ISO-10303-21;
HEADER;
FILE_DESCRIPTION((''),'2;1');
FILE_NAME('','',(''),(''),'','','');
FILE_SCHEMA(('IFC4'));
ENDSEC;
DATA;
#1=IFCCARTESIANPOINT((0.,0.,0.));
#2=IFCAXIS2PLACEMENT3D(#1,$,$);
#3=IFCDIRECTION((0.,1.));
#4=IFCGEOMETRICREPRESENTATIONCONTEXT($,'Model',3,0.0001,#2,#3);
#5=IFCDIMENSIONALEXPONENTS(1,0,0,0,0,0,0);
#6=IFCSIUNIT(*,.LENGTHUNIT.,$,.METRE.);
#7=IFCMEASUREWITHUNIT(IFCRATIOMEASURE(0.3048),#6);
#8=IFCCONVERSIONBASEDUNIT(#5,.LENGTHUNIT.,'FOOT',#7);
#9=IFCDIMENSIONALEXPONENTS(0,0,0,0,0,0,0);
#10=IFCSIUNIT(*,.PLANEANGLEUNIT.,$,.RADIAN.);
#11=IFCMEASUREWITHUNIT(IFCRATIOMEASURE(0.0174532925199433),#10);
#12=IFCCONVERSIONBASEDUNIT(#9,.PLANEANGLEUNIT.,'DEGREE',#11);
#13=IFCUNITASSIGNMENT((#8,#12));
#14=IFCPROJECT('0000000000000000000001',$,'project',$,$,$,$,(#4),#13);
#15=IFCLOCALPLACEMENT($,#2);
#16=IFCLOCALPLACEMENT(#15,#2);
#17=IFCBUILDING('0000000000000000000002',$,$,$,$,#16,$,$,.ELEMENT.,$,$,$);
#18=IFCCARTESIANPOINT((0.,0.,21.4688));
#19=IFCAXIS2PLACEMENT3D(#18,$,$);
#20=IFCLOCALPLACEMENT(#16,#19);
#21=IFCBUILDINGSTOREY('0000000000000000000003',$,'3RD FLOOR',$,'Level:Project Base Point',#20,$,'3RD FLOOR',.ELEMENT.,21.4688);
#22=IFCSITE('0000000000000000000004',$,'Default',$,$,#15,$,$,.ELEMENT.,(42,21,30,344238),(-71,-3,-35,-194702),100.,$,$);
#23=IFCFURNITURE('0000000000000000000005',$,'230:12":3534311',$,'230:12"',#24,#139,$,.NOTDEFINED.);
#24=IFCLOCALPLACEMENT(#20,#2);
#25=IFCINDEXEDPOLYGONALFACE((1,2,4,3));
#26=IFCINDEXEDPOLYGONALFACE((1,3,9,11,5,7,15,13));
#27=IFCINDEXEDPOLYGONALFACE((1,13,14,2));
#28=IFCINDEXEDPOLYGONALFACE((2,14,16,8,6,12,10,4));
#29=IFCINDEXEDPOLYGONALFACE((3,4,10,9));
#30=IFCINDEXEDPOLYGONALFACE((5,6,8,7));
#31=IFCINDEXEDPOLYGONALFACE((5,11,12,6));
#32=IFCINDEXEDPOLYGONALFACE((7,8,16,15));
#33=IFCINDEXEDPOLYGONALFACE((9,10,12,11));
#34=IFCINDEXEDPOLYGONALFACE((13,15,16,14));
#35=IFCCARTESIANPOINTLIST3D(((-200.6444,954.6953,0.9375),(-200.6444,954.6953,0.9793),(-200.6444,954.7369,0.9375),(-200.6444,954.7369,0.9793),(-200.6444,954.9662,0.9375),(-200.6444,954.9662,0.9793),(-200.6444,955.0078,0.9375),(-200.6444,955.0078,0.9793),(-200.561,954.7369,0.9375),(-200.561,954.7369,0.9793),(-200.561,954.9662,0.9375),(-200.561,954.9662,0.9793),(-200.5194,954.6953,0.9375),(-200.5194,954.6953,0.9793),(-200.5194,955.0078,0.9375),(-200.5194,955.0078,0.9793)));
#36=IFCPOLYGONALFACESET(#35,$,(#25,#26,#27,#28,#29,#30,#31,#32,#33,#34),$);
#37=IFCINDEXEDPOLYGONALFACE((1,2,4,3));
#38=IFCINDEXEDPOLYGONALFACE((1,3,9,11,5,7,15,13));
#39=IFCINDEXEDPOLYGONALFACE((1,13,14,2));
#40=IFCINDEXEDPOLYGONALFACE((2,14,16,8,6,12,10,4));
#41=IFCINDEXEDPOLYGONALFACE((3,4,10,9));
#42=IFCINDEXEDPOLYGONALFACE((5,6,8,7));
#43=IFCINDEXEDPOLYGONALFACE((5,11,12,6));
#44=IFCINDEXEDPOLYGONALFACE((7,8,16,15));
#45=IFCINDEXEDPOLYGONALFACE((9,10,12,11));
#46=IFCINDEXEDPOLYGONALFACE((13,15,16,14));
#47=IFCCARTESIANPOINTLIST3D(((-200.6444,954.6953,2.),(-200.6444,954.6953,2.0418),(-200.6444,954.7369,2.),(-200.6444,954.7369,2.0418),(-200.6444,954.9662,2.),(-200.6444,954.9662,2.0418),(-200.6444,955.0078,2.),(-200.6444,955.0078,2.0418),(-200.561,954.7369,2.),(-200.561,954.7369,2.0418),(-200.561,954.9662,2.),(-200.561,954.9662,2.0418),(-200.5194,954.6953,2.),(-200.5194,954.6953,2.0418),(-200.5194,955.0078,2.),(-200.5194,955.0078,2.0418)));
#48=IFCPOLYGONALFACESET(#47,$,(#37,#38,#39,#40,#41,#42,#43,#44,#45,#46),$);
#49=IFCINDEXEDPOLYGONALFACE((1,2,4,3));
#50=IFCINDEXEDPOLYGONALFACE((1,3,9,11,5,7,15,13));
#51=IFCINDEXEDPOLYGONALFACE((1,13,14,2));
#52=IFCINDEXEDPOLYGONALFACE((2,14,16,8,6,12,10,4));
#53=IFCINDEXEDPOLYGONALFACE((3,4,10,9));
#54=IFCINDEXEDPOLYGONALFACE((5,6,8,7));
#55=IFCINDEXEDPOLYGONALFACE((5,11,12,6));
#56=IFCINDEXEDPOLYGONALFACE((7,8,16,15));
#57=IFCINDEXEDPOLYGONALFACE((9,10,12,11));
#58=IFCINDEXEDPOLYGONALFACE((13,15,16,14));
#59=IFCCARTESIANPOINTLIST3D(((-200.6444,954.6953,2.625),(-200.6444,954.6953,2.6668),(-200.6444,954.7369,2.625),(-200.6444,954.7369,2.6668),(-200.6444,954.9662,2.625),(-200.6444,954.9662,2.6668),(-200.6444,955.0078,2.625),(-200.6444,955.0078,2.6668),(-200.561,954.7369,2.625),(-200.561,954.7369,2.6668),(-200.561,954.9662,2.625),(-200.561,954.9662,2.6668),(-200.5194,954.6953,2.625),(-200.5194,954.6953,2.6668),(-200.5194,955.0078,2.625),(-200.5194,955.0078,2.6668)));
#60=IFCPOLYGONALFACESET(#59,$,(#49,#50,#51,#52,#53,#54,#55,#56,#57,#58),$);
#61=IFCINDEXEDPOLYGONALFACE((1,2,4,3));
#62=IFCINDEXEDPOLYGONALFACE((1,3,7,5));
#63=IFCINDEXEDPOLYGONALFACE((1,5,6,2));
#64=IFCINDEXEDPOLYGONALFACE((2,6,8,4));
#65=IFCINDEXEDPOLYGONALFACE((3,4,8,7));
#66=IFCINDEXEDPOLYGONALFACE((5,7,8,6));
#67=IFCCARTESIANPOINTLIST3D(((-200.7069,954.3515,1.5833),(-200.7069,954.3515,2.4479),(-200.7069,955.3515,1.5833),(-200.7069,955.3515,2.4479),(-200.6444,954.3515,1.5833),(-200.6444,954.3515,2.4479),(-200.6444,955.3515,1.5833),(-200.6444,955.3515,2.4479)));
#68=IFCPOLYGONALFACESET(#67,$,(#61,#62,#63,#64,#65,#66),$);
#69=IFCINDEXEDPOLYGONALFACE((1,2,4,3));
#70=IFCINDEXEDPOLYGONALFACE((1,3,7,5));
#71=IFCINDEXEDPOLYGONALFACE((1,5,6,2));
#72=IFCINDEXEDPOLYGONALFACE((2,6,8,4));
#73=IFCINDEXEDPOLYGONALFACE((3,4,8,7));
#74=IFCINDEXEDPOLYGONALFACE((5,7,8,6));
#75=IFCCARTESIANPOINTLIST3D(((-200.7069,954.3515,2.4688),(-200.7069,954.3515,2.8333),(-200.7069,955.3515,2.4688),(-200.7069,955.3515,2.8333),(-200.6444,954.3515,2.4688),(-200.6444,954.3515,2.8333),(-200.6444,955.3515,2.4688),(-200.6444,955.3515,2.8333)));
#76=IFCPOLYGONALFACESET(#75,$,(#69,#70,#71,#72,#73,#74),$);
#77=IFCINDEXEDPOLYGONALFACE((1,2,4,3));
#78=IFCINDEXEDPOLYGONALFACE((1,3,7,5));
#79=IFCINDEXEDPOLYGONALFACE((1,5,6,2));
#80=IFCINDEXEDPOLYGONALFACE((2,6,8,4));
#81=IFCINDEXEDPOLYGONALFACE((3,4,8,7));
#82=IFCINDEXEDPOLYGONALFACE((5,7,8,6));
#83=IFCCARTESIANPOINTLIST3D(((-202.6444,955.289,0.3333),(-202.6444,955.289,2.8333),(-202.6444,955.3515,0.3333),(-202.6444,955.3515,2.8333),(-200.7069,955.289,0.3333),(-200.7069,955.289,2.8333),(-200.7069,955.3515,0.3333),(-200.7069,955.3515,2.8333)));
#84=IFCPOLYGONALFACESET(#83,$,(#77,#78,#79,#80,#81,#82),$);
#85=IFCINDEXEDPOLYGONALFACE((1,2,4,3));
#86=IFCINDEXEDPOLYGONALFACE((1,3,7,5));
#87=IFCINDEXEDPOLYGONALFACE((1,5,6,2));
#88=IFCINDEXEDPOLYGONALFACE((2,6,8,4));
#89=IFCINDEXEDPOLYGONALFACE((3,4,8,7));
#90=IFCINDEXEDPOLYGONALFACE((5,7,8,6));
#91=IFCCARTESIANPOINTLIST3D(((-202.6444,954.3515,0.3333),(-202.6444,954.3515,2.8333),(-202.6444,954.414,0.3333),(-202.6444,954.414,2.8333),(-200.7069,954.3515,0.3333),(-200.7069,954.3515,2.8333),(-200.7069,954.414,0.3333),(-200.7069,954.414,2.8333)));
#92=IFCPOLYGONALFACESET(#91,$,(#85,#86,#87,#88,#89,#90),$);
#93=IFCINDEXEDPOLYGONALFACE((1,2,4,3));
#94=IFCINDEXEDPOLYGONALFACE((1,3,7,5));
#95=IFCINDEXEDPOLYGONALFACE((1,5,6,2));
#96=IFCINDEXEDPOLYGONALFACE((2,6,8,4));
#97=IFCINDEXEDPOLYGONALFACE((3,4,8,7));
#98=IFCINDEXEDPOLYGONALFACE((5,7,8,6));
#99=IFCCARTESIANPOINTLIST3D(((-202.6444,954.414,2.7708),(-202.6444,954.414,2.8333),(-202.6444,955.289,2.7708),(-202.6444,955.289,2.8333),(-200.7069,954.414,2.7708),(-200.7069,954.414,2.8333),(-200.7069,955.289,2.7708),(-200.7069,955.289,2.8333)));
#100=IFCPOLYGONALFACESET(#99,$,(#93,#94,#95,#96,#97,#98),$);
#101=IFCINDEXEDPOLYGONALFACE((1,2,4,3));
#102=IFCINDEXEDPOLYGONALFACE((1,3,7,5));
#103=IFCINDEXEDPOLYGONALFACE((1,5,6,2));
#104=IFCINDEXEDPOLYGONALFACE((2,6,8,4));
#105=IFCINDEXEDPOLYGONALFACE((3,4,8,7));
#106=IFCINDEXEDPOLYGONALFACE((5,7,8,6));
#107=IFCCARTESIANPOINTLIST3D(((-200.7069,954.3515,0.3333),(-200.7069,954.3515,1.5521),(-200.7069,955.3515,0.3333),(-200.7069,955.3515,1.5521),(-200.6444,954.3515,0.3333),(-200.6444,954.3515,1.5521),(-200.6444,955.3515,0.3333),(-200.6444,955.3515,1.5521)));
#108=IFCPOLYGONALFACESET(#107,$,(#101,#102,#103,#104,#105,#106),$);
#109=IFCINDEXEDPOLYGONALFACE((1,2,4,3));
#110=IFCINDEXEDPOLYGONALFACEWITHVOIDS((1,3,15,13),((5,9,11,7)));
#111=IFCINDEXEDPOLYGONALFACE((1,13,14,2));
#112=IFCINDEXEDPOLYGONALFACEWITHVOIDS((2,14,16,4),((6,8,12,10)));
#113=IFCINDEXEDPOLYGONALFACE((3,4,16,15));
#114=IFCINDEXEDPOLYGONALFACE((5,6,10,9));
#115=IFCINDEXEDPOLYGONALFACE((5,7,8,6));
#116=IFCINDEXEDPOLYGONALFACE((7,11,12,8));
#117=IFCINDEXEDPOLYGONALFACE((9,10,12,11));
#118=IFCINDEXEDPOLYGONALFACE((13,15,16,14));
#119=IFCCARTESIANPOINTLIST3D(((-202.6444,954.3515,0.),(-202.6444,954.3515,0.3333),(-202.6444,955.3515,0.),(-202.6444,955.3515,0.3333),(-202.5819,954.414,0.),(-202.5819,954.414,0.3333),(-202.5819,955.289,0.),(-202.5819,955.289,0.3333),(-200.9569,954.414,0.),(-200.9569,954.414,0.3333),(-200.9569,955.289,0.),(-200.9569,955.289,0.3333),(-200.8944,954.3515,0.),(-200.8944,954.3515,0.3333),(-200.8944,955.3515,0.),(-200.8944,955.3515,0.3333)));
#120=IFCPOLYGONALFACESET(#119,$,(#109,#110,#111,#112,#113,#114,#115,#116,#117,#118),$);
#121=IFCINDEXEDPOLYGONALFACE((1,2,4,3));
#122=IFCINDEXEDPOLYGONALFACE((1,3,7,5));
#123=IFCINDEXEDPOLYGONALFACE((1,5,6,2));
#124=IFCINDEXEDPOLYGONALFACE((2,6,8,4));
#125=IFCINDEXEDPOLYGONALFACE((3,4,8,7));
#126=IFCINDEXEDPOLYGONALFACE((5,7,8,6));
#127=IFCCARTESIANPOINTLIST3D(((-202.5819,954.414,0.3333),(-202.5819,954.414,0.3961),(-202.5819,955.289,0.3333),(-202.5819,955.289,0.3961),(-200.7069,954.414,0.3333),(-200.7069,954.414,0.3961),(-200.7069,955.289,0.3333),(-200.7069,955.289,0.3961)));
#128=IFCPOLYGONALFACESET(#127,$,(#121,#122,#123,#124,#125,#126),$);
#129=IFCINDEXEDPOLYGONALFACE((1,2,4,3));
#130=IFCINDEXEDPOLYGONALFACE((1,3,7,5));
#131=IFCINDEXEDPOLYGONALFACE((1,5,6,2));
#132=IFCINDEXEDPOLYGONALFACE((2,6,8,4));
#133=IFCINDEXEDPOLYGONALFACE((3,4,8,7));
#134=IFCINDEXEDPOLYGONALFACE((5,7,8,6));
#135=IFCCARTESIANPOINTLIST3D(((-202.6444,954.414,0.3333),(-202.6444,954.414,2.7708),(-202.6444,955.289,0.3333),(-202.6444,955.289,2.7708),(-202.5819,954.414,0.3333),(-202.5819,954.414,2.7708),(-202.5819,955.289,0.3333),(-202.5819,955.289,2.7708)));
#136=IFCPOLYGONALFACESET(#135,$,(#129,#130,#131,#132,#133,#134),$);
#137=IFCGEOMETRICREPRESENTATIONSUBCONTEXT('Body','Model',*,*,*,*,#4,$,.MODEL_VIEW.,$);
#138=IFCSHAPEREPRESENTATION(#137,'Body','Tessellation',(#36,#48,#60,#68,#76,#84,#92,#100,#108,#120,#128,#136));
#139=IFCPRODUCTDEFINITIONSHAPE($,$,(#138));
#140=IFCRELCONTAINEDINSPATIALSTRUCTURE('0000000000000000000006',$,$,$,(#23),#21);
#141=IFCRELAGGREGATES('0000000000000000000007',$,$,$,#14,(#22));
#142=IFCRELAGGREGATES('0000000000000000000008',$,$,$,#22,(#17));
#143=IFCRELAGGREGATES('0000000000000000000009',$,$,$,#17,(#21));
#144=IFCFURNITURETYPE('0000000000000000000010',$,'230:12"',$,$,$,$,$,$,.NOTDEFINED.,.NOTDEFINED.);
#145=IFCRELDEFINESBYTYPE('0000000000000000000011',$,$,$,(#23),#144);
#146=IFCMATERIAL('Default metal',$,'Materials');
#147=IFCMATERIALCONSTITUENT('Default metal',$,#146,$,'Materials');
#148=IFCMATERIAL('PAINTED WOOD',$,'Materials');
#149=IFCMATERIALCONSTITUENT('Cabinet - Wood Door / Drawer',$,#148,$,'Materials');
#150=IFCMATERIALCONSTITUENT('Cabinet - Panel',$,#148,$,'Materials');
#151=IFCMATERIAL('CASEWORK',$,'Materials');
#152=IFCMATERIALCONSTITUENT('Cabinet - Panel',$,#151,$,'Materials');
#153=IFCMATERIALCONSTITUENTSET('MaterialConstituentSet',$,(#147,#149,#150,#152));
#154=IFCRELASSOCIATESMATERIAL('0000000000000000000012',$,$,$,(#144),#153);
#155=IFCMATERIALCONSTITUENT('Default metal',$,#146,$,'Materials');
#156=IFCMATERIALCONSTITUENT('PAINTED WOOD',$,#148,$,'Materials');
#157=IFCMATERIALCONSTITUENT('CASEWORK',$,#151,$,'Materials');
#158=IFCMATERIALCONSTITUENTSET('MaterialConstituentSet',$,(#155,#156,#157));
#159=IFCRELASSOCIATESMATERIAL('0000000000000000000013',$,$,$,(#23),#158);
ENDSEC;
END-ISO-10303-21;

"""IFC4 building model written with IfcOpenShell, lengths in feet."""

from ifc_helpers import new_model, entity, si_unit, converted_unit, direction, frame, frame_2d, origin, origin_2d_with_axis, place, context, subcontext, project, spatial, polyline, rectangle, outline, extrude, source, transform, mapped, material, constituent, constituent_set, type_object, type_shapes, element, save


model = new_model("IFC4")

# Units and contexts
model_context = context("Model", 3, precision=0.0001, world=origin(), true_north=direction((0.0, 1.0)))
body_context = subcontext(model_context, "Body", "Model", "MODEL_VIEW")
ifc_project = project(units=[converted_unit("LENGTHUNIT", "FOOT", entity("IfcRatioMeasure", 0.3048), si_unit("LENGTHUNIT", "METRE"), dimensions=[1, 0, 0, 0, 0, 0, 0]), converted_unit("PLANEANGLEUNIT", "DEGREE", entity("IfcRatioMeasure", 0.0174532925199433), si_unit("PLANEANGLEUNIT", "RADIAN"), dimensions=[0, 0, 0, 0, 0, 0, 0])], contexts=[model_context])

# Site, building, storey
site_placement = place(None, origin())
site = spatial("IfcSite", under=ifc_project, at=site_placement, Name="Default", CompositionType="ELEMENT", RefLatitude=(42, 21, 30, 344238), RefLongitude=(-71, -3, -35, -194702), RefElevation=100.0)
building_placement = place(site_placement, origin())
building = spatial("IfcBuilding", under=site, at=building_placement, CompositionType="ELEMENT")
storey_placement = place(building_placement, frame((0.0, 0.0, 21.4688)))
storey = spatial("IfcBuildingStorey", under=building, at=storey_placement, Name="3RD FLOOR", ObjectType="Level:Project Base Point", LongName="3RD FLOOR", CompositionType="ELEMENT", Elevation=21.4688)

# Furniture
ifc_material_1 = material(Name="Default metal", Category="Materials")
ifc_material_2 = material(Name="PAINTED WOOD", Category="Materials")
ifc_material_3 = material(Name="CASEWORK", Category="Materials")
ifc_constituent_1 = constituent(ifc_material_1, Name="Default metal", Category="Materials")
ifc_constituent_2 = constituent(ifc_material_2, Name="PAINTED WOOD", Category="Materials")
ifc_constituent_3 = constituent(ifc_material_3, Name="CASEWORK", Category="Materials")
ifc_constituent_set_1 = constituent_set(constituents=[ifc_constituent_1, ifc_constituent_2, ifc_constituent_3], Name="MaterialConstituentSet")
ifc_constituent_4 = constituent(ifc_material_1, Name="Default metal", Category="Materials")
ifc_constituent_5 = constituent(ifc_material_2, Name="Cabinet - Wood Door / Drawer", Category="Materials")
ifc_constituent_6 = constituent(ifc_material_2, Name="Cabinet - Panel", Category="Materials")
ifc_constituent_7 = constituent(ifc_material_3, Name="Cabinet - Panel", Category="Materials")
ifc_constituent_set_2 = constituent_set(constituents=[ifc_constituent_4, ifc_constituent_5, ifc_constituent_6, ifc_constituent_7], Name="MaterialConstituentSet")
furniture_type_1 = type_object("IfcFurnitureType", Name="230:12\"", AssemblyPlace="NOTDEFINED", PredefinedType="NOTDEFINED", material=ifc_constituent_set_2)
shared_shape_1 = source(origin(), body_context, "Body", "SweptSolid", [
    extrude(outline(polyline([(-0.1562, -0.0521), (-0.1146, -0.0521), (-0.1146, 0.0313), (0.1146, 0.0313), (0.1146, -0.0521), (0.1562, -0.0521), (0.1562, 0.0729), (-0.1562, 0.0729), (-0.1562, -0.0521)])), frame((0.0615, 2.0521, 0.9375)), (0.0, 0.0, 1.0), 0.0418),
    extrude(outline(polyline([(-0.1562, -0.0521), (-0.1146, -0.0521), (-0.1146, 0.0313), (0.1146, 0.0313), (0.1146, -0.0521), (0.1562, -0.0521), (0.1562, 0.0729), (-0.1562, 0.0729), (-0.1562, -0.0521)])), frame((0.0615, 2.0521, 2.0)), (0.0, 0.0, 1.0), 0.0418),
    extrude(outline(polyline([(-0.1562, -0.0521), (-0.1146, -0.0521), (-0.1146, 0.0313), (0.1146, 0.0313), (0.1146, -0.0521), (0.1562, -0.0521), (0.1562, 0.0729), (-0.1562, 0.0729), (-0.1562, -0.0521)])), frame((0.0615, 2.0521, 2.625)), (0.0, 0.0, 1.0), 0.0418),
    extrude(rectangle(XDim=1.0, YDim=0.0625, at=origin_2d_with_axis()), frame((0.0615, 1.9688, 1.5833), z_axis=(0.0, 0.0, 1.0), x_axis=(-1.0, 0.0, 0.0)), (0.0, 0.0, 1.0), 0.8646),
    extrude(rectangle(XDim=1.0, YDim=0.0625, at=origin_2d_with_axis()), frame((0.0615, 1.9688, 2.4688), z_axis=(0.0, 0.0, 1.0), x_axis=(-1.0, 0.0, 0.0)), (0.0, 0.0, 1.0), 0.3646),
    extrude(rectangle(XDim=1.9375, YDim=0.0625, at=frame_2d((0.0, 0.0), x_axis=(1.0, 0.0))), frame((-0.4073, 0.9687, 0.3333), z_axis=(0.0, 0.0, 1.0), x_axis=(0.0, -1.0, 0.0)), (0.0, 0.0, 1.0), 2.5),
    extrude(rectangle(XDim=1.9375, YDim=0.0625, at=frame_2d((0.0, 0.0), x_axis=(1.0, 0.0))), frame((0.5302, 0.9687, 0.3333), z_axis=(0.0, 0.0, 1.0), x_axis=(0.0, -1.0, 0.0)), (0.0, 0.0, 1.0), 2.5),
    extrude(rectangle(XDim=1.9375, YDim=0.875, at=origin_2d_with_axis()), frame((0.0615, 0.9687, 2.7708), z_axis=(0.0, 0.0, 1.0), x_axis=(0.0, 1.0, 0.0)), (0.0, 0.0, 1.0), 0.0625),
    extrude(rectangle(XDim=1.0, YDim=0.0625, at=origin_2d_with_axis()), frame((0.0615, 1.9688, 0.3333), z_axis=(0.0, 0.0, 1.0), x_axis=(-1.0, 0.0, 0.0)), (0.0, 0.0, 1.0), 1.2187),
    extrude(outline(polyline([(-0.875, -0.5), (0.875, -0.5), (0.875, 0.5), (-0.875, 0.5), (-0.875, -0.5)]), holes=[polyline([(-0.8125, -0.4375), (-0.8125, 0.4375), (0.8125, 0.4375), (0.8125, -0.4375), (-0.8125, -0.4375)])]), frame((0.0615, 0.875, 0.0), z_axis=(0.0, 0.0, 1.0), x_axis=(0.0, -1.0, 0.0)), (0.0, 0.0, 1.0), 0.3333),
    extrude(rectangle(XDim=1.875, YDim=0.875, at=origin_2d_with_axis()), frame((0.0615, 1.0, 0.3333), z_axis=(0.0, 0.0, 1.0), x_axis=(0.0, 1.0, 0.0)), (0.0, 0.0, 1.0), 0.0627),
    extrude(rectangle(XDim=0.875, YDim=0.0625, at=origin_2d_with_axis()), frame((0.0615, 0.0312, 0.3333), z_axis=(0.0, 0.0, 1.0), x_axis=(-1.0, 0.0, 0.0)), (0.0, 0.0, 1.0), 2.4375),
])
type_shapes(furniture_type_1, [shared_shape_1])
furniture_1_placement = place(storey_placement, frame((-202.6444, 954.913, 0.0), z_axis=(0.0, 0.0, 1.0), x_axis=(0.0, -1.0, 0.0)))
element("IfcFurniture", 1, at=furniture_1_placement, inside=storey, type_object=furniture_type_1, material=ifc_constituent_set_1, Name="230:12\":3534311", ObjectType="230:12\"", PredefinedType="NOTDEFINED", context=body_context, shape_type="MappedRepresentation", body=[
    mapped(shared_shape_1, transform((0.0, 0.0, 0.0), scale=1.0)),
])

save(model, "model.ifc")
